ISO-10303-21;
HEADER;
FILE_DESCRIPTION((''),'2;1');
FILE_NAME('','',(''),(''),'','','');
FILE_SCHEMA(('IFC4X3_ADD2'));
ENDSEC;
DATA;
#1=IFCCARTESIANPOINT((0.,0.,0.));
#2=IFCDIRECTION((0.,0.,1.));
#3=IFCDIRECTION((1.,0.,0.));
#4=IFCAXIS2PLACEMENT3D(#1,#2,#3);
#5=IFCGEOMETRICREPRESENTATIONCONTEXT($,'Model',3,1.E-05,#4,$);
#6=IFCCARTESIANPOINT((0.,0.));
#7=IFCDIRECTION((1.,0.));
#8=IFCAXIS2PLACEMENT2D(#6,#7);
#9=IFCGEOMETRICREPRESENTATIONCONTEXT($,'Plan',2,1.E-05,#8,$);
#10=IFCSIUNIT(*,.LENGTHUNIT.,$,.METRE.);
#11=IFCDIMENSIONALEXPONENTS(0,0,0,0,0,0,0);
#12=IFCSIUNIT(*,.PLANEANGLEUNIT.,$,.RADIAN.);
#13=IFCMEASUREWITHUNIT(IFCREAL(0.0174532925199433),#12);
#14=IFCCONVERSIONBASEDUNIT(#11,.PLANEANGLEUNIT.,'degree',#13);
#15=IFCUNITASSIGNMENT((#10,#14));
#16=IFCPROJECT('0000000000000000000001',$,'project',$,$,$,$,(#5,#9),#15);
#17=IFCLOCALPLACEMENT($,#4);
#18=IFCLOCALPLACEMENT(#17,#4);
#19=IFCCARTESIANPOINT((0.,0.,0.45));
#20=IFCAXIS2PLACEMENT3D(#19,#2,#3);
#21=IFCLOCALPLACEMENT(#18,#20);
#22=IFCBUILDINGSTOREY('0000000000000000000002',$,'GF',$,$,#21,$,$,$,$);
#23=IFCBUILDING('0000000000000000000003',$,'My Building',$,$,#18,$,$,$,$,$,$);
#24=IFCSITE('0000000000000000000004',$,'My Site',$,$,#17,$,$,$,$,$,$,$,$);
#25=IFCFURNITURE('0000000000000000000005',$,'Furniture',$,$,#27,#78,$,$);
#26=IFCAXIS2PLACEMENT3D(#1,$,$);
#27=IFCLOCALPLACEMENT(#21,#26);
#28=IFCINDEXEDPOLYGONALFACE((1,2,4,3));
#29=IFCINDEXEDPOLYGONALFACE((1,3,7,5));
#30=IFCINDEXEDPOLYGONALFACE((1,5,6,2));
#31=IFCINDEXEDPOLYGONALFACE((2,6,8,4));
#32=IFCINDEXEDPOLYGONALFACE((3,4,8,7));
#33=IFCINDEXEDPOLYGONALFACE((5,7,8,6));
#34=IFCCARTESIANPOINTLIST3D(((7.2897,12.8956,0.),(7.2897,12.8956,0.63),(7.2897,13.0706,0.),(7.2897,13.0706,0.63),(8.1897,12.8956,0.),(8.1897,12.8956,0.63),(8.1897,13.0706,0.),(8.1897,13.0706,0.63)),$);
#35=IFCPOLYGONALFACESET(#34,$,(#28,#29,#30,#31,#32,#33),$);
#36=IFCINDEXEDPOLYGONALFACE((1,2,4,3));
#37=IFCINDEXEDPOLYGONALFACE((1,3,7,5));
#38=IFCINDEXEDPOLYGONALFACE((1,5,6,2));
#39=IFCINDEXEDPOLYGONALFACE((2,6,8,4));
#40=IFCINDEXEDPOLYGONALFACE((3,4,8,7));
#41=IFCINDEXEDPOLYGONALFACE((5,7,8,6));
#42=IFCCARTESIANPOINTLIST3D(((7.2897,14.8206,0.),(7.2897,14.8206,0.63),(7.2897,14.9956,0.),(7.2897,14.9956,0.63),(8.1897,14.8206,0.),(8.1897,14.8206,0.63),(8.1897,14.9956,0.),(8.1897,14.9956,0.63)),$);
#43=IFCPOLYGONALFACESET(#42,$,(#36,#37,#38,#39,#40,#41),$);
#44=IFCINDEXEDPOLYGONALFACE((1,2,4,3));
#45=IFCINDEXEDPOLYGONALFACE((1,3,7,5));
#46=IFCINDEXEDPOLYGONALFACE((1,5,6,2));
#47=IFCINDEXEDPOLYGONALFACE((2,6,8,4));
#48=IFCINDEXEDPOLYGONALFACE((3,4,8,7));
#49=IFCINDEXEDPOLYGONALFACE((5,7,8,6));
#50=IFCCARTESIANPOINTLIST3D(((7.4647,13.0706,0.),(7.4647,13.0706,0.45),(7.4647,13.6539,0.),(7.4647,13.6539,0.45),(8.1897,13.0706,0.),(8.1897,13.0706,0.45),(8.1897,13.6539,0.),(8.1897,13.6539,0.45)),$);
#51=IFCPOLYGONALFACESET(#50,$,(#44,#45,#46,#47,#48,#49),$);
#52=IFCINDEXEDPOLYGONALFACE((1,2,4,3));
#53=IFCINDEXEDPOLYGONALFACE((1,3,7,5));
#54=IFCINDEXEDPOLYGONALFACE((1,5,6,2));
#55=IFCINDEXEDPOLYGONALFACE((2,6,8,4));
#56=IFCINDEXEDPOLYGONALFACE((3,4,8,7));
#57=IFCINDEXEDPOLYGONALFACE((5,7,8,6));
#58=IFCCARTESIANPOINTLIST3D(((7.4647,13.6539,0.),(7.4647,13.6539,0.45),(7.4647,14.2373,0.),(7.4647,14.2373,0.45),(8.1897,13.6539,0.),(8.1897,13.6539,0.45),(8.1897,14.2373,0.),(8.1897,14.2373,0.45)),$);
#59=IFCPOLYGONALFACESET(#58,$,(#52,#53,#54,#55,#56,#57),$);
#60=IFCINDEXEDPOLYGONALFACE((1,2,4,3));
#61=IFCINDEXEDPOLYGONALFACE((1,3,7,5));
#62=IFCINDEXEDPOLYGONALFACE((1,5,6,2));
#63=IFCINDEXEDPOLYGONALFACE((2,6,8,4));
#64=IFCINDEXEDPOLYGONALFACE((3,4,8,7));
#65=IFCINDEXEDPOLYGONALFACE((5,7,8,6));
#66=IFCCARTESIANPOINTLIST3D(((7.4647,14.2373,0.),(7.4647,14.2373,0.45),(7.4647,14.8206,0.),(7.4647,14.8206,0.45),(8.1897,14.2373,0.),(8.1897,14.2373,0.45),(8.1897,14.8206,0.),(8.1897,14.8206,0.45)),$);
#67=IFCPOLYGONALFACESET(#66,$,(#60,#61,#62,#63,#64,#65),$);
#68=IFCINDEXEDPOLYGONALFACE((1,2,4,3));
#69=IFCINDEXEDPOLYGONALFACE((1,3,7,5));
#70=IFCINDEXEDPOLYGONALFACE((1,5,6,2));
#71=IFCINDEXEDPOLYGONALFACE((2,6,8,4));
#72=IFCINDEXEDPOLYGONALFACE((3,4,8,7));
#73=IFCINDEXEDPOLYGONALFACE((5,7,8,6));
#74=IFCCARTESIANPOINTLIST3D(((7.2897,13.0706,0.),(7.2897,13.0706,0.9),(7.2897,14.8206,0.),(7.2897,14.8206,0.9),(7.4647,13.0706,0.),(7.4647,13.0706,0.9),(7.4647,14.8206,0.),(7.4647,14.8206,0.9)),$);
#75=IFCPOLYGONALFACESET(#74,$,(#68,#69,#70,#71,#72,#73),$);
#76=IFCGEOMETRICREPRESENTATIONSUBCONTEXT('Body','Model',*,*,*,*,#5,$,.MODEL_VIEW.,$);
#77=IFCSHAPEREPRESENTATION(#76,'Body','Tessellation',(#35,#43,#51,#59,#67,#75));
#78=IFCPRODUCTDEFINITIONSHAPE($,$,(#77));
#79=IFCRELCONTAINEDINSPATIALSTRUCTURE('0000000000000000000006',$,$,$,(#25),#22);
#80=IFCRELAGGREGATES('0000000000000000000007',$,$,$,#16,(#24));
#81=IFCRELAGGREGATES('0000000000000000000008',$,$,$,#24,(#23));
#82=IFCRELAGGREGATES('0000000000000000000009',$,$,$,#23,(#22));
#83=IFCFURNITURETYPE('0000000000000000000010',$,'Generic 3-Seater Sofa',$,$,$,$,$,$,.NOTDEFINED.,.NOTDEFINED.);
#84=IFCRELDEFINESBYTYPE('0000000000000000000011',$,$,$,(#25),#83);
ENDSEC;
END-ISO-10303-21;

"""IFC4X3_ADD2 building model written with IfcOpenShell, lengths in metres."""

from ifc_helpers import new_model, entity, si_unit, converted_unit, frame, origin_with_axes, origin_2d_with_axis, place, context, subcontext, project, spatial, line, indexed_curve, outline, extrude, shape, source, transform, mapped, type_object, type_shapes, element, save


model = new_model("IFC4X3_ADD2")

# Units and contexts
model_context = context("Model", 3, precision=1e-05, world=origin_with_axes())
plan_context = context("Plan", 2, precision=1e-05, world=origin_2d_with_axis())
body_context_1 = subcontext(model_context, "Body", "Model", "MODEL_VIEW")
body_context_2 = subcontext(plan_context, "Body", "Plan", "PLAN_VIEW")
ifc_project = project(units=[si_unit("LENGTHUNIT", "METRE"), converted_unit("PLANEANGLEUNIT", "degree", entity("IfcReal", 0.0174532925199433), si_unit("PLANEANGLEUNIT", "RADIAN"), dimensions=[0, 0, 0, 0, 0, 0, 0])], contexts=[model_context, plan_context])

# Site, building, storey
site_placement = place(None, origin_with_axes())
site = spatial("IfcSite", under=ifc_project, at=site_placement, Name="My Site")
building_placement = place(site_placement, origin_with_axes())
building = spatial("IfcBuilding", under=site, at=building_placement, Name="My Building")
storey_placement = place(building_placement, frame((0.0, 0.0, 0.45), z_axis=(0.0, 0.0, 1.0), x_axis=(1.0, 0.0, 0.0)))
storey = spatial("IfcBuildingStorey", under=building, at=storey_placement, Name="GF")

# Furniture
furniture_type = type_object("IfcFurnitureType", Name="Generic 3-Seater Sofa", AssemblyPlace="NOTDEFINED", PredefinedType="NOTDEFINED")
shared_shape_1 = source(origin_with_axes(), body_context_1, "Body", "SweptSolid", [
    extrude(outline(indexed_curve([(0.0, 0.0), (0.175, 0.0), (0.175, 0.9), (0.0, 0.9)], segments=[line(1, 2, 3, 4, 1)])), frame((-1.05, -0.9, 0.0), z_axis=(0.0, 0.0, 1.0), x_axis=(1.0, 0.0, 0.0)), (0.0, 0.0, 1.0), 0.63),
    extrude(outline(indexed_curve([(0.0, 0.0), (0.175, 0.0), (0.175, 0.9), (0.0, 0.9)], segments=[line(1, 2, 3, 4, 1)])), frame((0.875, -0.9, 0.0), z_axis=(0.0, 0.0, 1.0), x_axis=(1.0, 0.0, 0.0)), (0.0, 0.0, 1.0), 0.63),
    extrude(outline(indexed_curve([(0.175, 0.0), (0.7583, 0.0), (0.7583, 0.725), (0.175, 0.725)], segments=[line(1, 2, 3, 4, 1)])), frame((-1.05, -0.9, 0.0), z_axis=(0.0, 0.0, 1.0), x_axis=(1.0, 0.0, 0.0)), (0.0, 0.0, 1.0), 0.45),
    extrude(outline(indexed_curve([(0.7583, 0.0), (1.3417, 0.0), (1.3417, 0.725), (0.7583, 0.725)], segments=[line(1, 2, 3, 4, 1)])), frame((-1.05, -0.9, 0.0), z_axis=(0.0, 0.0, 1.0), x_axis=(1.0, 0.0, 0.0)), (0.0, 0.0, 1.0), 0.45),
    extrude(outline(indexed_curve([(1.3417, 0.0), (1.925, 0.0), (1.925, 0.725), (1.3417, 0.725)], segments=[line(1, 2, 3, 4, 1)])), frame((-1.05, -0.9, 0.0), z_axis=(0.0, 0.0, 1.0), x_axis=(1.0, 0.0, 0.0)), (0.0, 0.0, 1.0), 0.45),
    extrude(outline(indexed_curve([(0.175, 0.725), (1.925, 0.725), (1.925, 0.9), (0.175, 0.9)], segments=[line(1, 2, 3, 4, 1)])), frame((-1.05, -0.9, 0.0), z_axis=(0.0, 0.0, 1.0), x_axis=(1.0, 0.0, 0.0)), (0.0, 0.0, 1.0), 0.9),
])
shared_shape_2 = source(origin_with_axes(), body_context_2, "Body", "Curve2D", [
    entity("IfcIndexedPolyCurve", entity("IfcCartesianPointList2D", [[-1.05, -0.9], [-0.875, -0.9], [-0.875, 0.0], [-1.05, 0.0]]), [entity("IfcLineIndex", [1, 2, 3, 4, 1])]),
    entity("IfcIndexedPolyCurve", entity("IfcCartesianPointList2D", [[0.875, -0.9], [1.05, -0.9], [1.05, 0.0], [0.875, 0.0]]), [entity("IfcLineIndex", [1, 2, 3, 4, 1])]),
    entity("IfcIndexedPolyCurve", entity("IfcCartesianPointList2D", [[-0.875, -0.9], [-0.2917, -0.9], [-0.2917, -0.175], [-0.875, -0.175]]), [entity("IfcLineIndex", [1, 2, 3, 4, 1])]),
    entity("IfcIndexedPolyCurve", entity("IfcCartesianPointList2D", [[-0.2917, -0.9], [0.2917, -0.9], [0.2917, -0.175], [-0.2917, -0.175]]), [entity("IfcLineIndex", [1, 2, 3, 4, 1])]),
    entity("IfcIndexedPolyCurve", entity("IfcCartesianPointList2D", [[0.2917, -0.9], [0.875, -0.9], [0.875, -0.175], [0.2917, -0.175]]), [entity("IfcLineIndex", [1, 2, 3, 4, 1])]),
    entity("IfcIndexedPolyCurve", entity("IfcCartesianPointList2D", [[-0.875, -0.175], [0.875, -0.175], [0.875, 0.0], [-0.875, 0.0]]), [entity("IfcLineIndex", [1, 2, 3, 4, 1])]),
])
type_shapes(furniture_type, [shared_shape_1, shared_shape_2])
furniture_placement = place(storey_placement, frame((7.2897, 13.9456, 0.0), z_axis=(0.0, 0.0, 1.0), x_axis=(0.0, 1.0, 0.0)))
element("IfcFurniture", 1, at=furniture_placement, inside=storey, type_object=furniture_type, Name="Furniture", shapes=[
    shape(body_context_1, "Body", "MappedRepresentation", [mapped(shared_shape_1, transform((0.0, 0.0, 0.0), x_axis=(1.0, 0.0, 0.0), y_axis=(0.0, 1.0, 0.0), z_axis=(0.0, 0.0, 1.0), scale=1.0))]),
    shape(body_context_2, "Body", "MappedRepresentation", [mapped(shared_shape_2, transform((0.0, 0.0, 0.0), x_axis=(1.0, 0.0, 0.0), y_axis=(0.0, 1.0, 0.0), z_axis=(0.0, 0.0, 1.0), scale=1.0))]),
])

save(model, "model.ifc")
